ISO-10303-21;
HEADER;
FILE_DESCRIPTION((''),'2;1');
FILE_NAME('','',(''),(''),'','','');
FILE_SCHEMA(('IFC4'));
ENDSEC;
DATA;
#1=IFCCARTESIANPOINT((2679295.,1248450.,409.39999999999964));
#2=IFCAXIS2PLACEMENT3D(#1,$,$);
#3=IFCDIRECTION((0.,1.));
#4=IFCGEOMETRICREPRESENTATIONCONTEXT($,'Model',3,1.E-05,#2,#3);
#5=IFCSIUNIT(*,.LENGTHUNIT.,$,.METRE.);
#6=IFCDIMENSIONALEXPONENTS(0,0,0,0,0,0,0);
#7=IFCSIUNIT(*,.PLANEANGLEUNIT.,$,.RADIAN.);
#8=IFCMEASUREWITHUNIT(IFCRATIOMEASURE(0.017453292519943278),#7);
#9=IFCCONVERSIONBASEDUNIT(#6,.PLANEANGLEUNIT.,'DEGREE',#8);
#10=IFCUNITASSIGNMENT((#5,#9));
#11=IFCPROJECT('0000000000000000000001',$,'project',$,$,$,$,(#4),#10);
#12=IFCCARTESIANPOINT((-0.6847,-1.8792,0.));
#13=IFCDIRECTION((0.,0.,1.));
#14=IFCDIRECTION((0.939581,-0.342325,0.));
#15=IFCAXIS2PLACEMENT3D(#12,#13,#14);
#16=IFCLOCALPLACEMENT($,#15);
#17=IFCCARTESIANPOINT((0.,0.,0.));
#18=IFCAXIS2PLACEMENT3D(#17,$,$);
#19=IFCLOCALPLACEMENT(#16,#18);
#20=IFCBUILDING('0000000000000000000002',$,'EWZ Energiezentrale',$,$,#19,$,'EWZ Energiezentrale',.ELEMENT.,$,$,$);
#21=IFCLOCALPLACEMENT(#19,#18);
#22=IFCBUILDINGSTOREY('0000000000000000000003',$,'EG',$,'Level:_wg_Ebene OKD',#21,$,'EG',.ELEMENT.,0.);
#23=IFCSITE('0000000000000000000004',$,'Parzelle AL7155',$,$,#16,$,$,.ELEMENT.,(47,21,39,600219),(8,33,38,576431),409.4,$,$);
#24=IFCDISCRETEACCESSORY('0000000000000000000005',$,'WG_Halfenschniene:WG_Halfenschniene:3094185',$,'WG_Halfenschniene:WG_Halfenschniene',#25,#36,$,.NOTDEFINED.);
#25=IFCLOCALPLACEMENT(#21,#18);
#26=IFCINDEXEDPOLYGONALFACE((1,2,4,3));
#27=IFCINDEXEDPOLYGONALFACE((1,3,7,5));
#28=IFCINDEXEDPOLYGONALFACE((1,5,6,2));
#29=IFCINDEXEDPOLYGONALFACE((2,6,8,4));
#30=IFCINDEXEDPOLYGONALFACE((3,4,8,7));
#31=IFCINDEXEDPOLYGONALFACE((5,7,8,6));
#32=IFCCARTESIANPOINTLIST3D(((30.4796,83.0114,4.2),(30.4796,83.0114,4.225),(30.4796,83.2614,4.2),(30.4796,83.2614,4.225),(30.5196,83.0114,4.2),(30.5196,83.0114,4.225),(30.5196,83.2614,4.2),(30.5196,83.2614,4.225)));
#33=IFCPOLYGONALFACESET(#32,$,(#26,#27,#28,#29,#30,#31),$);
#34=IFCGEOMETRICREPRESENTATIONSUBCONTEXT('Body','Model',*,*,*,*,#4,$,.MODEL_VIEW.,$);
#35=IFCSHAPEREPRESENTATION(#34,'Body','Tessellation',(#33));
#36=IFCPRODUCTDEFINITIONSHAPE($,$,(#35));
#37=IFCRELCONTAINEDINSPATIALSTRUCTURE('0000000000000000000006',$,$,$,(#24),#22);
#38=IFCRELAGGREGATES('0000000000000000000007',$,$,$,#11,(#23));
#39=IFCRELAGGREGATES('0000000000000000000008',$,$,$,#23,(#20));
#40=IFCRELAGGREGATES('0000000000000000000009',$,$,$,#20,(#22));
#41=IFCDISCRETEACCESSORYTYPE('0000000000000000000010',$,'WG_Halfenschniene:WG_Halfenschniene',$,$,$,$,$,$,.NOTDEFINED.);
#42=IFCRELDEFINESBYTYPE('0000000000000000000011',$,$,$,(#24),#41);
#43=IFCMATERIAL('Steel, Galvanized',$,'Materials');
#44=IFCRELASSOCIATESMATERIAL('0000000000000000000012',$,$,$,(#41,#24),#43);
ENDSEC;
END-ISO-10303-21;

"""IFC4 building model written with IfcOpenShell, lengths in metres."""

from ifc_helpers import new_model, entity, si_unit, converted_unit, direction, frame, origin, place, context, subcontext, project, spatial, indexed_curve, outline, extrude, source, transform, mapped, material, type_object, element, save


model = new_model("IFC4")

# Units and contexts
model_context = context("Model", 3, precision=1e-05, world=frame((2679295.0, 1248450.0, 409.39999999999964)), true_north=direction((0.0, 1.0)))
body_context = subcontext(model_context, "Body", "Model", "MODEL_VIEW")
ifc_project = project(units=[si_unit("LENGTHUNIT", "METRE"), converted_unit("PLANEANGLEUNIT", "DEGREE", entity("IfcRatioMeasure", 0.017453292519943278), si_unit("PLANEANGLEUNIT", "RADIAN"), dimensions=[0, 0, 0, 0, 0, 0, 0])], contexts=[model_context])

# Site, building, storey
site_placement = place(None, frame((-0.6847, -1.8792, 0.0), z_axis=(0.0, 0.0, 1.0), x_axis=(0.939581, -0.342325, 0.0)))
site = spatial("IfcSite", under=ifc_project, at=site_placement, Name="Parzelle AL7155", CompositionType="ELEMENT", RefLatitude=(47, 21, 39, 600219), RefLongitude=(8, 33, 38, 576431), RefElevation=409.4)
building_placement = place(site_placement, origin())
building = spatial("IfcBuilding", under=site, at=building_placement, Name="EWZ Energiezentrale", LongName="EWZ Energiezentrale", CompositionType="ELEMENT")
storey_placement = place(building_placement, origin())
storey = spatial("IfcBuildingStorey", under=building, at=storey_placement, Name="EG", ObjectType="Level:_wg_Ebene OKD", LongName="EG", CompositionType="ELEMENT", Elevation=0.0)

# Discrete accessory
ifc_material = material(Name="Steel, Galvanized", Category="Materials")
discrete_accessory_type = type_object("IfcDiscreteAccessoryType", Name="WG_Halfenschniene:WG_Halfenschniene", PredefinedType="NOTDEFINED", material=ifc_material)
shared_shape = source(origin(), body_context, "Body", "SweptSolid", [
    extrude(outline(indexed_curve([(-0.125, -0.02), (0.125, -0.02), (0.125, 0.02), (-0.125, 0.02), (-0.125, -0.02)], self_intersect=False)), frame((0.125, 0.0, -0.0125)), (0.0, 0.0, 1.0), 0.025),
])
for number, where, z_axis, x_axis, name in (
    (1, (30.4996, 83.0114, 4.2125), (0.0, 0.0, -1.0), (0.0, 1.0, 0.0), "WG_Halfenschniene:WG_Halfenschniene:3094185"),
):
    element("IfcDiscreteAccessory", number, at=place(storey_placement, frame(where, z_axis=z_axis, x_axis=x_axis)), inside=storey, type_object=discrete_accessory_type, material=ifc_material, Name=name, ObjectType="WG_Halfenschniene:WG_Halfenschniene", PredefinedType="NOTDEFINED", context=body_context, shape_type="MappedRepresentation", body=[
        mapped(shared_shape, transform((0.0, 0.0, 0.0), scale=1.0)),
    ])

save(model, "model.ifc")
